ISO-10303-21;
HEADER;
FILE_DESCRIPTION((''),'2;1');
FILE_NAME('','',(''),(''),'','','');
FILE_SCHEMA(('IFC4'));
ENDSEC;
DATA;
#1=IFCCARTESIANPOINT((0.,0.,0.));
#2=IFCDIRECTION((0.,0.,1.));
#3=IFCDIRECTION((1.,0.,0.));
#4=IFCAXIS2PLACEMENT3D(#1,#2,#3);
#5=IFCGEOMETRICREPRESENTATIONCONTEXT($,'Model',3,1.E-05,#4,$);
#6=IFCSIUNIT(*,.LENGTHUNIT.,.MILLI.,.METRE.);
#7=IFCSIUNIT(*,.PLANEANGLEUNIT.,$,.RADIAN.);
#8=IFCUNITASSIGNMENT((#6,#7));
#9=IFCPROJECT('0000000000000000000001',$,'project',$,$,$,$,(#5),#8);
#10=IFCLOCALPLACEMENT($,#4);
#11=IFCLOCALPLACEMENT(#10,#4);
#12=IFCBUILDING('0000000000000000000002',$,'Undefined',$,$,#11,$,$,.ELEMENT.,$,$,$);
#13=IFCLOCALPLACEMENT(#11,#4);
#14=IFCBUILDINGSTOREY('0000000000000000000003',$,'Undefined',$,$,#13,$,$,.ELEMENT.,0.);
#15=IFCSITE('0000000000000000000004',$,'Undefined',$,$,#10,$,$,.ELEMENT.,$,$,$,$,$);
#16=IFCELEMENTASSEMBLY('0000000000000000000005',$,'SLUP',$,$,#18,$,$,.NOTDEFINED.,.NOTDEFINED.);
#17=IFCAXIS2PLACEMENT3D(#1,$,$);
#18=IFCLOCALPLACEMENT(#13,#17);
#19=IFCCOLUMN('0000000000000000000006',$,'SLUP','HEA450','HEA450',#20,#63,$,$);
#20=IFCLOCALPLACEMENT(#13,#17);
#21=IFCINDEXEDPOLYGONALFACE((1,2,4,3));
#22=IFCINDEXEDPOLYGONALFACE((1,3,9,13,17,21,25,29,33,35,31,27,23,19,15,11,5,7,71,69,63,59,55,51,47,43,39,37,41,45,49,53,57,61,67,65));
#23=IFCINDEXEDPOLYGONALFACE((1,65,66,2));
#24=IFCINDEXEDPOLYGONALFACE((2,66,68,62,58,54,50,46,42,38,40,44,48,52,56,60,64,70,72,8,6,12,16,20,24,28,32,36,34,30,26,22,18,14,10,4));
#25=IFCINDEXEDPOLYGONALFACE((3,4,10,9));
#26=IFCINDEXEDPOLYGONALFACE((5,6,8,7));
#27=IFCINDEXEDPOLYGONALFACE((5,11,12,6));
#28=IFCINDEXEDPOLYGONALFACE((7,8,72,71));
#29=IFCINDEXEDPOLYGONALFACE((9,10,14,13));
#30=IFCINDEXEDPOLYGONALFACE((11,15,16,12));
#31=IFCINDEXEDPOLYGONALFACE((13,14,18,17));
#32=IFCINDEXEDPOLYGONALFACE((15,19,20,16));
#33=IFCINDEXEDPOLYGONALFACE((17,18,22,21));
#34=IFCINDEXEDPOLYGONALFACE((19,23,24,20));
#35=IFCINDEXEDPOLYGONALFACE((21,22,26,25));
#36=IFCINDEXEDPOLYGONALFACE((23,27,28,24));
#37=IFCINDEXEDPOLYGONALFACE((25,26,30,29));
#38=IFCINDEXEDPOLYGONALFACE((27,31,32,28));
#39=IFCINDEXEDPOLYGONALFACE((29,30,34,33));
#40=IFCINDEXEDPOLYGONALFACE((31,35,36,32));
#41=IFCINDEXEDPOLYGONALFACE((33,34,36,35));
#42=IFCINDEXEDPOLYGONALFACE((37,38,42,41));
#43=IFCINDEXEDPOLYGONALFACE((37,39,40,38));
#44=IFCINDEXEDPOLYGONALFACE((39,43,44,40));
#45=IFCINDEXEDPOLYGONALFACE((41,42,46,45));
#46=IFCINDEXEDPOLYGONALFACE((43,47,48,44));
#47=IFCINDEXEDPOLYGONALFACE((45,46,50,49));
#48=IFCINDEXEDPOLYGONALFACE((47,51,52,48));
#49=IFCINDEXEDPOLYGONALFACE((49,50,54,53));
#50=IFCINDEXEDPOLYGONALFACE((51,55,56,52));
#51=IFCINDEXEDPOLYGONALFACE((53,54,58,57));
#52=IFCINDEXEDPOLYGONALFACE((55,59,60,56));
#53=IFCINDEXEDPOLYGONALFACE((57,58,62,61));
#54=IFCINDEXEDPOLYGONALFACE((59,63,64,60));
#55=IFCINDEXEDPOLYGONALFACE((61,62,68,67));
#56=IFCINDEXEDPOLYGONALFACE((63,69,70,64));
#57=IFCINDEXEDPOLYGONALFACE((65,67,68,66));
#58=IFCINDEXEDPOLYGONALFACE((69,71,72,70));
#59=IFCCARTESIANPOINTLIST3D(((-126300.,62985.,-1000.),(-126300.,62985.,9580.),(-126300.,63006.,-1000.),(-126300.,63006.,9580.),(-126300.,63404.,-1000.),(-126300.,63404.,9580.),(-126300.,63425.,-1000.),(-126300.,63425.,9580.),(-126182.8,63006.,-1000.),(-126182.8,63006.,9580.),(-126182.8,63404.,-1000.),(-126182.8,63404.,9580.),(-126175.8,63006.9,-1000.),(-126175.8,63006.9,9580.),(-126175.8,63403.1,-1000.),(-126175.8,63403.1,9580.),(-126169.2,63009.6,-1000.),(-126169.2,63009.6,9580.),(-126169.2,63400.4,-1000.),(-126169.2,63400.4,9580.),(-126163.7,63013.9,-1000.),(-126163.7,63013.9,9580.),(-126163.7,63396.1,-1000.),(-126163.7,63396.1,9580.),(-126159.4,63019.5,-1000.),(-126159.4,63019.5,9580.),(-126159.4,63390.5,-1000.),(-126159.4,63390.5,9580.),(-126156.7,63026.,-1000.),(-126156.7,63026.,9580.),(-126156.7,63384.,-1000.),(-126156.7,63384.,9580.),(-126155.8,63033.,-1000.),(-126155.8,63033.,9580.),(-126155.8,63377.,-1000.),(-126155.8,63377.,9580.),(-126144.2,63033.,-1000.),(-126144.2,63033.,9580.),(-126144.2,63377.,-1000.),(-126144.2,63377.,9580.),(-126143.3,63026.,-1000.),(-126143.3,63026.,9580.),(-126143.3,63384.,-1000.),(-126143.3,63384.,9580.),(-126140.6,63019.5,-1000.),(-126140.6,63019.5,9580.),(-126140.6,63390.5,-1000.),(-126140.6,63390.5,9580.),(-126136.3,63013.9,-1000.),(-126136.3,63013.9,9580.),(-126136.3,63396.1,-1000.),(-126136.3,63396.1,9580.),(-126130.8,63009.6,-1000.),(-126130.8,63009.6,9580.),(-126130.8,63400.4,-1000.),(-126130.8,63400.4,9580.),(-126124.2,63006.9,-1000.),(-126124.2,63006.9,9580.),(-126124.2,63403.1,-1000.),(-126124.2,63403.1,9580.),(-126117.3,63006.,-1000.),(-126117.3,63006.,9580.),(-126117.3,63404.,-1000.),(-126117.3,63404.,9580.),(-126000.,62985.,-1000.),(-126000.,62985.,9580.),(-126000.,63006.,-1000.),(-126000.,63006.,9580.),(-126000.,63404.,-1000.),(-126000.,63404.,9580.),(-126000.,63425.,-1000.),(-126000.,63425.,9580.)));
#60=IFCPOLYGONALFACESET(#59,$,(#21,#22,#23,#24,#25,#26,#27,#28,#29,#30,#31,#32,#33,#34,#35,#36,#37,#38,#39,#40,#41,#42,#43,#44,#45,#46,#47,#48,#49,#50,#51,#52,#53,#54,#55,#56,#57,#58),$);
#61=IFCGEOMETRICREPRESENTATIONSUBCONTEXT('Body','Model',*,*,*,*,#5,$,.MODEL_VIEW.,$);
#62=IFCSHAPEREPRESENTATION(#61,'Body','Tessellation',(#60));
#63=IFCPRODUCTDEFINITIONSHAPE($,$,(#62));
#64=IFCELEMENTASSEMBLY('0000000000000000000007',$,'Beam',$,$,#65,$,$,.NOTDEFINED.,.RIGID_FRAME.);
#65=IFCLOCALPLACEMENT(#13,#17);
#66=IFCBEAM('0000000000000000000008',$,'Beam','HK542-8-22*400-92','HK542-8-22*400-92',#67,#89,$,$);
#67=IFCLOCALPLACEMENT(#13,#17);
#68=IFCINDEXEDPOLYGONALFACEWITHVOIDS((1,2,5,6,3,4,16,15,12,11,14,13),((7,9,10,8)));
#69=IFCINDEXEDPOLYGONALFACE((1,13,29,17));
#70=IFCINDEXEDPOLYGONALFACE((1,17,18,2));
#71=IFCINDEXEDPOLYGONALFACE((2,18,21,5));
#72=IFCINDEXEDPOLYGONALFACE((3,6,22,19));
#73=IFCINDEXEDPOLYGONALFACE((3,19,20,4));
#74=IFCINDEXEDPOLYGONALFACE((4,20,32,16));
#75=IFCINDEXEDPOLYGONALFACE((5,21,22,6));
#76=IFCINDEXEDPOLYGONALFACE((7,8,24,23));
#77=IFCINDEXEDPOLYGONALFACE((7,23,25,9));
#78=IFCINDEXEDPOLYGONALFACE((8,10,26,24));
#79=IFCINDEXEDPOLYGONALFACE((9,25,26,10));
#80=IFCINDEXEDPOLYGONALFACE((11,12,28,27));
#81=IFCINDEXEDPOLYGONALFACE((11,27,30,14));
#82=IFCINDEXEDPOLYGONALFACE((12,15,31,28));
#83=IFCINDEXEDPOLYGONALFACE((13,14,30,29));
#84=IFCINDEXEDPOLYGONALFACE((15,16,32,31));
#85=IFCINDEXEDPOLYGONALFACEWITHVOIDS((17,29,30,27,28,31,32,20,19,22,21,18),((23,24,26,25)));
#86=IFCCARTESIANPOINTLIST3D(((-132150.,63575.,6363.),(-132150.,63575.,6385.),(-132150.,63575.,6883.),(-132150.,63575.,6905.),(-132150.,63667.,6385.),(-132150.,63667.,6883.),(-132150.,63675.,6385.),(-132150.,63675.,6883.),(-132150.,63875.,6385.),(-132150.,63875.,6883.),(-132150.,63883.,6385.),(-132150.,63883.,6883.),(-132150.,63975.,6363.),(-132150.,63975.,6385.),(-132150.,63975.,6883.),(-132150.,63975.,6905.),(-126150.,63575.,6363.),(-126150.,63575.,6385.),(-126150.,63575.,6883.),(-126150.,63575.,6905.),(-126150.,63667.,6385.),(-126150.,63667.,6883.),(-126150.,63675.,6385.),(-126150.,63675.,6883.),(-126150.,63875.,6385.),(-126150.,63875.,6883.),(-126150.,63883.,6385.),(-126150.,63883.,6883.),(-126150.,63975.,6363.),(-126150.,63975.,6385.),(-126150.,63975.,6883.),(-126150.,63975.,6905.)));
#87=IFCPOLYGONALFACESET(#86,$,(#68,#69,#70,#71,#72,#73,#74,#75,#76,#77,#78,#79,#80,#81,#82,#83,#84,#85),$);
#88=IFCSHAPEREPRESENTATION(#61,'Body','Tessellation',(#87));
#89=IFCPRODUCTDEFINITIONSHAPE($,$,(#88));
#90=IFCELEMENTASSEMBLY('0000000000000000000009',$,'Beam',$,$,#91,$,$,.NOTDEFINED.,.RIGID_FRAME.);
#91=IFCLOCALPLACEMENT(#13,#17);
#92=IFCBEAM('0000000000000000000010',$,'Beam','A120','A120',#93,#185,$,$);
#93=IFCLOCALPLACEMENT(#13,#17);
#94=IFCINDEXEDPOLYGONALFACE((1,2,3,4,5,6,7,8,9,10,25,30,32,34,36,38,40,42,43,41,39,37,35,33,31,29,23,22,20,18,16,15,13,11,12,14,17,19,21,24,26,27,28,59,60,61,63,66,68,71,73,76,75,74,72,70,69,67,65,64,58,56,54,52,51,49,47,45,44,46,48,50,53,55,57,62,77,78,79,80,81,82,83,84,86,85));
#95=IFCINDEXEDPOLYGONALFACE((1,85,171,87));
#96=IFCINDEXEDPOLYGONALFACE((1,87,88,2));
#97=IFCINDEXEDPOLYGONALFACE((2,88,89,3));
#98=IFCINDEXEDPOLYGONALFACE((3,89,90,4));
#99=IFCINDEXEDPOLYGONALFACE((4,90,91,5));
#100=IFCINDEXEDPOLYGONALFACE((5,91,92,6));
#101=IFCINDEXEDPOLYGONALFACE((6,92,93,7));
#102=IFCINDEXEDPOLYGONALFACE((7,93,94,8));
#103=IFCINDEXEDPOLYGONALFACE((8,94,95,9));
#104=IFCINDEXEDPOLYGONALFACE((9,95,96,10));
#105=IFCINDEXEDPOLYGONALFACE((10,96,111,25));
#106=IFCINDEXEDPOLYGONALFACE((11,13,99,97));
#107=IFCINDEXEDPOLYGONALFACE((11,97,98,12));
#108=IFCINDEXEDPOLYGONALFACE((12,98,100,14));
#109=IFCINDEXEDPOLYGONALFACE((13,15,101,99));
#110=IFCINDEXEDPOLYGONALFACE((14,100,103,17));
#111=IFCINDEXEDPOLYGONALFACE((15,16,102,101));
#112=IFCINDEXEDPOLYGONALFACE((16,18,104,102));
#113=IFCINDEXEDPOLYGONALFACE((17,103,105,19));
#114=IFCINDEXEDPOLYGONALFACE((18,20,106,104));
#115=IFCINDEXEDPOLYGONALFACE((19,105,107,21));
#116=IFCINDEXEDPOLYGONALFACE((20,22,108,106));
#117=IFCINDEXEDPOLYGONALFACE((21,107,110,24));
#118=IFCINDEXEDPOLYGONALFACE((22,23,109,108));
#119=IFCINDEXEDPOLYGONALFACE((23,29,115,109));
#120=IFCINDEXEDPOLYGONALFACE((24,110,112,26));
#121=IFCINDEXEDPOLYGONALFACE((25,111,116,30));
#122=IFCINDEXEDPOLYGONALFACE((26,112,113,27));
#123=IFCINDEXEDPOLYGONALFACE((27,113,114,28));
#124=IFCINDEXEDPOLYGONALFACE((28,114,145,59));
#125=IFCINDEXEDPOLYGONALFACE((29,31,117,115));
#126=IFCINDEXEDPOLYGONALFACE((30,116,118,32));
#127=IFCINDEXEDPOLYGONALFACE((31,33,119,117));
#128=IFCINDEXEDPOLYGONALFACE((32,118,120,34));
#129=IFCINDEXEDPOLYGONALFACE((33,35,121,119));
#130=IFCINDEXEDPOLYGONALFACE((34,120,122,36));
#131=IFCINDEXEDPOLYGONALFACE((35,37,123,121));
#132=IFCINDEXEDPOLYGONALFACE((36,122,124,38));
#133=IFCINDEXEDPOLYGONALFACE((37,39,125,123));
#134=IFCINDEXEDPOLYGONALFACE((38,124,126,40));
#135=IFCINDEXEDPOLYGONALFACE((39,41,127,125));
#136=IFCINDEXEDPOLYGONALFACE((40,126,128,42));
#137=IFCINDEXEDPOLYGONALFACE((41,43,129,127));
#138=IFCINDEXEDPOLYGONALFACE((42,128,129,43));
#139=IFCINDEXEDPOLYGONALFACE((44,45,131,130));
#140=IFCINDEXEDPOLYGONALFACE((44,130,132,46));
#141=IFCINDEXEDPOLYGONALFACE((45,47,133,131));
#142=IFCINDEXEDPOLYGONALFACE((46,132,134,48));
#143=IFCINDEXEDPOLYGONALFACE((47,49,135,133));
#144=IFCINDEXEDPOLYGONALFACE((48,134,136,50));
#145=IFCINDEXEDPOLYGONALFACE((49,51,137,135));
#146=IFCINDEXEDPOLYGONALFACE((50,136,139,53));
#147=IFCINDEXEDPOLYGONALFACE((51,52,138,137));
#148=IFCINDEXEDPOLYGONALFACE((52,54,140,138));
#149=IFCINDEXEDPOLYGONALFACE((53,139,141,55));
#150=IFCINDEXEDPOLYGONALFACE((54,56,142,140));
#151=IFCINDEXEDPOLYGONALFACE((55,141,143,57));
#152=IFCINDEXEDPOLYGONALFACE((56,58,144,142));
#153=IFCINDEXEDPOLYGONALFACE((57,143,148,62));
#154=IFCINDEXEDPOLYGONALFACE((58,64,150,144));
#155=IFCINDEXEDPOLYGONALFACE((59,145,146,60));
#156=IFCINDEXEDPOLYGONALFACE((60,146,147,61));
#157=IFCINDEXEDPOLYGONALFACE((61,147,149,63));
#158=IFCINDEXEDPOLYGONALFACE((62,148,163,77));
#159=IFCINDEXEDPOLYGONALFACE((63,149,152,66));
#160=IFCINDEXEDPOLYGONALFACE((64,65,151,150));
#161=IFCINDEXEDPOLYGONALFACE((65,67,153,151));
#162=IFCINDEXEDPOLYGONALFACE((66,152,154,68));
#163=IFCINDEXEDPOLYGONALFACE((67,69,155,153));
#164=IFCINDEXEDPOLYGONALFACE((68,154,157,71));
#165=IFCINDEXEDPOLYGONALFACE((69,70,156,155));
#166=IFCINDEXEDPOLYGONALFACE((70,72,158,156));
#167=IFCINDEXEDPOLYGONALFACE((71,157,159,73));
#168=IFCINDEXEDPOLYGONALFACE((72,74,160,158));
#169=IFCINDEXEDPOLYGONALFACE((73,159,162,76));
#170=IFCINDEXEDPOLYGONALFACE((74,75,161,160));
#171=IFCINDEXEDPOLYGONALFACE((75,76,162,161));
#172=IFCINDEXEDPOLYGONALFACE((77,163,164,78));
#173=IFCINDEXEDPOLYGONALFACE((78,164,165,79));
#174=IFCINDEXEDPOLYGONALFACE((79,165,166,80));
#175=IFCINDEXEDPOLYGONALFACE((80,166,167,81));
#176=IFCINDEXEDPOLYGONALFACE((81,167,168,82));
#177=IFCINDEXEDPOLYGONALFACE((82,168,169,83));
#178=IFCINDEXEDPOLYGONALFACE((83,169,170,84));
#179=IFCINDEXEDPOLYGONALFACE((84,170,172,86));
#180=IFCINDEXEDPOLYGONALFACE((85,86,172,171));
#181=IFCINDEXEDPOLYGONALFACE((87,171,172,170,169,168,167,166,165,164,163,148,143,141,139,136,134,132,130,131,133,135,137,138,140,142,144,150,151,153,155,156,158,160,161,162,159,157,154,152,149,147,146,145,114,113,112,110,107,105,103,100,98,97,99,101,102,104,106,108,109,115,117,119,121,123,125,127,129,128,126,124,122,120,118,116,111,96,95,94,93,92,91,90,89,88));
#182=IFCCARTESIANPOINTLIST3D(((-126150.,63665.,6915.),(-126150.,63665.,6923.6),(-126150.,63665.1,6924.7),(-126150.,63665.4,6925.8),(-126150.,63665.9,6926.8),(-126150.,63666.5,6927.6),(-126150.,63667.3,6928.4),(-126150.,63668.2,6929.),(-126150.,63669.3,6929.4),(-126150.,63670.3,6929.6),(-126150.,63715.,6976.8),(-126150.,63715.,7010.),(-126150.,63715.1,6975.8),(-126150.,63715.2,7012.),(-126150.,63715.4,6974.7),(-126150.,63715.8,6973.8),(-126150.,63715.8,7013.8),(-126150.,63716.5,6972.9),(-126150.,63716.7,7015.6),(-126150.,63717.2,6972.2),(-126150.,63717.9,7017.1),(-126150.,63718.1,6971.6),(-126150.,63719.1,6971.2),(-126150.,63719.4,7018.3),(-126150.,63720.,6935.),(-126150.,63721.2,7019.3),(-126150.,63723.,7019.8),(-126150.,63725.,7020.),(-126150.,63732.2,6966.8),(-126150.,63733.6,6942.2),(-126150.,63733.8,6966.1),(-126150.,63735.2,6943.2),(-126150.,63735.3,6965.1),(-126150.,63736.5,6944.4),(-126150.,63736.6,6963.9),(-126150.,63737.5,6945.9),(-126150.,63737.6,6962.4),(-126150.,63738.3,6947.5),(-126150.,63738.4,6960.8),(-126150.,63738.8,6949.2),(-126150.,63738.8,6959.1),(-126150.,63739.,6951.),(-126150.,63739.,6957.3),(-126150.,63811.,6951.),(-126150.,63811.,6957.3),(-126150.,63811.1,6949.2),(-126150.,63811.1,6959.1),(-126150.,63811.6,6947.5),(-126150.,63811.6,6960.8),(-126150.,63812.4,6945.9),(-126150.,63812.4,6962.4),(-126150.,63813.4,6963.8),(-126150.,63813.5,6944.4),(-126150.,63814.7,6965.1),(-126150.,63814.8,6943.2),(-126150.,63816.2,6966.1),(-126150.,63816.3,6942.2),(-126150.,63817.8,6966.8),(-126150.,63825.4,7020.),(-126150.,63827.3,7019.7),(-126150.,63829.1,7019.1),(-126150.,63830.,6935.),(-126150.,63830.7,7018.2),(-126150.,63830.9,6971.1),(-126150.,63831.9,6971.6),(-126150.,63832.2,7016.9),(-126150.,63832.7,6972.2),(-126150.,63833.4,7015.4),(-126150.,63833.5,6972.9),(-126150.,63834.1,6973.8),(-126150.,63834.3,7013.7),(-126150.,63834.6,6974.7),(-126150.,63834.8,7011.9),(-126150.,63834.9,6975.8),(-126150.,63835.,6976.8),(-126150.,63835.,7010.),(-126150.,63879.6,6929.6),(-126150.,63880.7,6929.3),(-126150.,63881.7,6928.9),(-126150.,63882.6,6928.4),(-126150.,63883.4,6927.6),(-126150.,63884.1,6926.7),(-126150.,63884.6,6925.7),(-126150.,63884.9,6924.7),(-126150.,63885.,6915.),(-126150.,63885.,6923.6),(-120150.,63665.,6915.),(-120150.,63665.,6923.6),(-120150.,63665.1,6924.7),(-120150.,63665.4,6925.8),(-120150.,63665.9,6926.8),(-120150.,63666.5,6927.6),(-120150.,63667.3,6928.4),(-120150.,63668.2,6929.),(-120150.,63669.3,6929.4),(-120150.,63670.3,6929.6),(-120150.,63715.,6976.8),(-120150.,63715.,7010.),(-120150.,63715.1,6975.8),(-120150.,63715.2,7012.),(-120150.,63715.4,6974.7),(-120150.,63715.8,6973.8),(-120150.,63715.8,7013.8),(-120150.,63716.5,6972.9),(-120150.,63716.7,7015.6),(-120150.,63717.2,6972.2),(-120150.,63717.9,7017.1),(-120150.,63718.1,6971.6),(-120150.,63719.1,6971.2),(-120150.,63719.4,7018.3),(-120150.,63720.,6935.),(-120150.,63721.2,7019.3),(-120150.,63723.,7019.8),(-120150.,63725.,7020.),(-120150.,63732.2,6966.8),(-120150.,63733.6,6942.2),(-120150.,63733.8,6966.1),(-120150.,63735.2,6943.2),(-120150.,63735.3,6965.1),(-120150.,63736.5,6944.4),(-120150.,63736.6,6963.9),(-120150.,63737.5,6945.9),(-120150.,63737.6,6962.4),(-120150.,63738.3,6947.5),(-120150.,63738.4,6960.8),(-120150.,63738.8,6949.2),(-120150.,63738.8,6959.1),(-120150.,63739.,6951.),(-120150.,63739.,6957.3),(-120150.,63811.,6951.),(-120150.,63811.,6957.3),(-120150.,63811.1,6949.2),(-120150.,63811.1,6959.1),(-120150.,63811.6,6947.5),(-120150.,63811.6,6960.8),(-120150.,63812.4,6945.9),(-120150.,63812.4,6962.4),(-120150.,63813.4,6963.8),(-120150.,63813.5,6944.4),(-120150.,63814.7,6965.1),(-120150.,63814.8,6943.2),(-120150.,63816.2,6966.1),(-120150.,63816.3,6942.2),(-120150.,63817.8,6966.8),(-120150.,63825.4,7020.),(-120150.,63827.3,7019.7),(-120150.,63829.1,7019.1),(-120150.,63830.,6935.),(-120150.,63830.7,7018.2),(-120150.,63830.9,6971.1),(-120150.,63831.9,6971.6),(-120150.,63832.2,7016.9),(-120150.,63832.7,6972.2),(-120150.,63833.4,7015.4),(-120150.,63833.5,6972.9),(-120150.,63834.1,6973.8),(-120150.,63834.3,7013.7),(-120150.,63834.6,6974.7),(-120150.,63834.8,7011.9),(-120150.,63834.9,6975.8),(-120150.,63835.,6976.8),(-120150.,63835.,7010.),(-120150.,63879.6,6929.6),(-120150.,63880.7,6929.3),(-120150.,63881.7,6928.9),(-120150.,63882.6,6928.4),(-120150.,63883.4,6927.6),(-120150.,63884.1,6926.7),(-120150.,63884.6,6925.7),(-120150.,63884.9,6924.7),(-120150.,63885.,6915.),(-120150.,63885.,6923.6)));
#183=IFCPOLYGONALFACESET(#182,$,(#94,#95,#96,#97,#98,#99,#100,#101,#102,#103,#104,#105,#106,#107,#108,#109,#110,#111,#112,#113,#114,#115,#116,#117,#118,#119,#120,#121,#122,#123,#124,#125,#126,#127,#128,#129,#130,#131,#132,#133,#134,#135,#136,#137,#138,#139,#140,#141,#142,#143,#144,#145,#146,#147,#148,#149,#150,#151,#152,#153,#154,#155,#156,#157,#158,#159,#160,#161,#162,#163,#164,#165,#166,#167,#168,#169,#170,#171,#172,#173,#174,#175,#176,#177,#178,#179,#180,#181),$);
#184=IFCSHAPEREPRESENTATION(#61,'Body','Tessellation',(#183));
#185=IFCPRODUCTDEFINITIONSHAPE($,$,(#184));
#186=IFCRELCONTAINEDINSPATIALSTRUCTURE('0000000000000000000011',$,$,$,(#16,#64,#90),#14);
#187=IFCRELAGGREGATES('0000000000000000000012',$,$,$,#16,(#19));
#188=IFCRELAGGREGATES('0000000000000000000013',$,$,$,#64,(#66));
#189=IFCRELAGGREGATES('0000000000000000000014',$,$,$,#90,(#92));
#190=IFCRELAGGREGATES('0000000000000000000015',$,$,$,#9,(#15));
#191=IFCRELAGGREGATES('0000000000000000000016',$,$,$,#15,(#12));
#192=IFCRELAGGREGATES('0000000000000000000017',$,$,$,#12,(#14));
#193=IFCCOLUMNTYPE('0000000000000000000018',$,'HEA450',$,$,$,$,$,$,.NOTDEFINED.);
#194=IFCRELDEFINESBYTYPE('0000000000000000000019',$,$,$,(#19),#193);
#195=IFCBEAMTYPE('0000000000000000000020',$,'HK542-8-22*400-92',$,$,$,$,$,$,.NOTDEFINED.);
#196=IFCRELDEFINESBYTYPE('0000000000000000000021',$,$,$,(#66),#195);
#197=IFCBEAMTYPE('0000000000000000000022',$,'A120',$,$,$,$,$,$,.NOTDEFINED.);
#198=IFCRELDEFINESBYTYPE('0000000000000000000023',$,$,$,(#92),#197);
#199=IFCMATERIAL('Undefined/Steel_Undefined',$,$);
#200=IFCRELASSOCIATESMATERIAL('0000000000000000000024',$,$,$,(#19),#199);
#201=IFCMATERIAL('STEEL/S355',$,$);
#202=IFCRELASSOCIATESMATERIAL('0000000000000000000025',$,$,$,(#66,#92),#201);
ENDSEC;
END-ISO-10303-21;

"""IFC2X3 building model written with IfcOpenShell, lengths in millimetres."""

from ifc_helpers import new_model, si_unit, frame, origin_with_axes, origin_2d_with_axis, place, context, subcontext, project, spatial, polyline, i_section, outline, extrude, material, type_object, element, aggregate, save


model = new_model("IFC2X3")

# Units and contexts
model_context = context("Model", 3, precision=1e-05, world=origin_with_axes())
body_context = subcontext(model_context, "Body", "Model", "MODEL_VIEW")
ifc_project = project(units=[si_unit("LENGTHUNIT", "METRE", prefix="MILLI"), si_unit("PLANEANGLEUNIT", "RADIAN")], contexts=[model_context])

# Site, building, storey
site_placement = place(None, origin_with_axes())
site = spatial("IfcSite", under=ifc_project, at=site_placement, Name="Undefined", CompositionType="ELEMENT")
building_placement = place(site_placement, origin_with_axes())
building = spatial("IfcBuilding", under=site, at=building_placement, Name="Undefined", CompositionType="ELEMENT")
storey_placement = place(building_placement, origin_with_axes())
storey = spatial("IfcBuildingStorey", under=building, at=storey_placement, Name="Undefined", CompositionType="ELEMENT", Elevation=0.0)

# Element assembly, column
assembly_1_placement = place(storey_placement, origin_with_axes())
assembly_1 = element("IfcElementAssembly", 1, at=assembly_1_placement, inside=storey, Name="SLUP", AssemblyPlace="NOTDEFINED", PredefinedType="NOTDEFINED")
ifc_material_1 = material(Name="Undefined/Steel_Undefined")
column_type = type_object("IfcColumnType", Name="HEA450", PredefinedType="NOTDEFINED")
column_placement = place(assembly_1_placement, frame((-126150.0, 63205.0, -1000.0), z_axis=(0.0, 0.0, 1.0), x_axis=(0.0, 1.0, 0.0)))
column = element("IfcColumn", 2, at=column_placement, type_object=column_type, material=ifc_material_1, Name="SLUP", Description="HEA450", ObjectType="HEA450", context=body_context, shape_type="SweptSolid", body=[
    extrude(i_section(OverallWidth=300.0, OverallDepth=440.0, WebThickness=11.5, FlangeThickness=21.0, FilletRadius=27.0, at=origin_2d_with_axis()), frame((0.0, 0.0, 10580.0), z_axis=(0.0, 0.0, -1.0), x_axis=(0.0, 1.0, 0.0)), (0.0, 0.0, 1.0), 10580.0),
])
aggregate(assembly_1, [column])

# Element assemblies, beams
assembly_2_placement = place(storey_placement, origin_with_axes())
assembly_2 = element("IfcElementAssembly", 3, at=assembly_2_placement, inside=storey, Name="Beam", AssemblyPlace="NOTDEFINED", PredefinedType="RIGID_FRAME")
ifc_material_2 = material(Name="STEEL/S355")
beam_type_1 = type_object("IfcBeamType", Name="HK542-8-22*400-92", PredefinedType="NOTDEFINED")
beam_1_placement = place(assembly_2_placement, frame((-126150.0, 63775.0, 6634.0), z_axis=(0.0, 0.0, 1.0), x_axis=(-1.0, 0.0, 0.0)))
beam_1 = element("IfcBeam", 4, at=beam_1_placement, type_object=beam_type_1, material=ifc_material_2, Name="Beam", Description="HK542-8-22*400-92", ObjectType="HK542-8-22*400-92", context=body_context, shape_type="SweptSolid", body=[
    extrude(outline(polyline([(-200.0, 249.0), (-200.0, 271.0), (200.0, 271.0), (200.0, 249.0), (108.0, 249.0), (108.0, -249.0), (200.0, -249.0), (200.0, -271.0), (-200.0, -271.0), (-200.0, -249.0), (-108.0, -249.0), (-108.0, 249.0), (-200.0, 249.0)]), holes=[polyline([(-100.0, -249.0), (100.0, -249.0), (100.0, 249.0), (-100.0, 249.0), (-100.0, -249.0)])]), frame((6000.0, 0.0, 0.0), z_axis=(-1.0, 0.0, 0.0), x_axis=(0.0, -1.0, 0.0)), (0.0, 0.0, 1.0), 6000.0),
])
aggregate(assembly_2, [beam_1])
assembly_3_placement = place(storey_placement, origin_with_axes())
assembly_3 = element("IfcElementAssembly", 5, at=assembly_3_placement, inside=storey, Name="Beam", AssemblyPlace="NOTDEFINED", PredefinedType="RIGID_FRAME")
beam_type_2 = type_object("IfcBeamType", Name="A120", PredefinedType="NOTDEFINED")
beam_2_placement = place(assembly_3_placement, frame((-126150.0, 63775.0, 6967.5), z_axis=(0.0, 0.000118, 1.0), x_axis=(1.0, 0.0, 0.0)))
beam_2 = element("IfcBeam", 6, at=beam_2_placement, type_object=beam_type_2, material=ifc_material_2, Name="Beam", Description="A120", ObjectType="A120", context=body_context, shape_type="SweptSolid", body=[
    extrude(outline(polyline([(-110.0, -52.5), (-110.0, -43.9), (-109.9, -42.8), (-109.6, -41.8), (-109.1, -40.8), (-108.5, -39.9), (-107.7, -39.1), (-106.7, -38.6), (-105.7, -38.2), (-104.7, -37.9), (-55.0, -32.5), (-41.3, -25.3), (-39.8, -24.3), (-38.5, -23.1), (-37.4, -21.6), (-36.6, -20.0), (-36.2, -18.3), (-36.0, -16.5), (-36.0, -10.2), (-36.1, -8.4), (-36.6, -6.7), (-37.4, -5.1), (-38.4, -3.7), (-39.7, -2.4), (-41.2, -1.4), (-42.8, -0.7), (-55.9, 3.6), (-56.9, 4.1), (-57.8, 4.7), (-58.5, 5.4), (-59.2, 6.3), (-59.6, 7.2), (-59.9, 8.3), (-60.0, 9.3), (-60.0, 42.5), (-59.8, 44.4), (-59.3, 46.2), (-58.4, 47.9), (-57.2, 49.4), (-55.7, 50.7), (-54.1, 51.6), (-52.3, 52.2), (-50.4, 52.5), (50.0, 52.5), (51.9, 52.3), (53.8, 51.7), (55.5, 50.8), (57.1, 49.6), (58.3, 48.1), (59.2, 46.3), (59.8, 44.4), (60.0, 42.5), (60.0, 9.3), (59.9, 8.3), (59.6, 7.2), (59.2, 6.3), (58.5, 5.4), (57.8, 4.7), (56.9, 4.1), (55.9, 3.6), (42.8, -0.7), (41.2, -1.4), (39.7, -2.4), (38.4, -3.7), (37.4, -5.1), (36.6, -6.7), (36.1, -8.4), (36.0, -10.2), (36.0, -16.5), (36.2, -18.3), (36.6, -20.0), (37.4, -21.6), (38.5, -23.1), (39.8, -24.3), (41.3, -25.3), (55.0, -32.5), (104.7, -37.9), (105.7, -38.2), (106.7, -38.6), (107.7, -39.1), (108.5, -39.9), (109.1, -40.8), (109.6, -41.8), (109.9, -42.8), (110.0, -43.9), (110.0, -52.5), (-110.0, -52.5)])), frame((6000.0, 0.0, 0.0), z_axis=(-1.0, 0.0, 0.0), x_axis=(0.0, -1.0, 0.0)), (0.0, 0.0, 1.0), 6000.0),
])
aggregate(assembly_3, [beam_2])

save(model, "model.ifc")
